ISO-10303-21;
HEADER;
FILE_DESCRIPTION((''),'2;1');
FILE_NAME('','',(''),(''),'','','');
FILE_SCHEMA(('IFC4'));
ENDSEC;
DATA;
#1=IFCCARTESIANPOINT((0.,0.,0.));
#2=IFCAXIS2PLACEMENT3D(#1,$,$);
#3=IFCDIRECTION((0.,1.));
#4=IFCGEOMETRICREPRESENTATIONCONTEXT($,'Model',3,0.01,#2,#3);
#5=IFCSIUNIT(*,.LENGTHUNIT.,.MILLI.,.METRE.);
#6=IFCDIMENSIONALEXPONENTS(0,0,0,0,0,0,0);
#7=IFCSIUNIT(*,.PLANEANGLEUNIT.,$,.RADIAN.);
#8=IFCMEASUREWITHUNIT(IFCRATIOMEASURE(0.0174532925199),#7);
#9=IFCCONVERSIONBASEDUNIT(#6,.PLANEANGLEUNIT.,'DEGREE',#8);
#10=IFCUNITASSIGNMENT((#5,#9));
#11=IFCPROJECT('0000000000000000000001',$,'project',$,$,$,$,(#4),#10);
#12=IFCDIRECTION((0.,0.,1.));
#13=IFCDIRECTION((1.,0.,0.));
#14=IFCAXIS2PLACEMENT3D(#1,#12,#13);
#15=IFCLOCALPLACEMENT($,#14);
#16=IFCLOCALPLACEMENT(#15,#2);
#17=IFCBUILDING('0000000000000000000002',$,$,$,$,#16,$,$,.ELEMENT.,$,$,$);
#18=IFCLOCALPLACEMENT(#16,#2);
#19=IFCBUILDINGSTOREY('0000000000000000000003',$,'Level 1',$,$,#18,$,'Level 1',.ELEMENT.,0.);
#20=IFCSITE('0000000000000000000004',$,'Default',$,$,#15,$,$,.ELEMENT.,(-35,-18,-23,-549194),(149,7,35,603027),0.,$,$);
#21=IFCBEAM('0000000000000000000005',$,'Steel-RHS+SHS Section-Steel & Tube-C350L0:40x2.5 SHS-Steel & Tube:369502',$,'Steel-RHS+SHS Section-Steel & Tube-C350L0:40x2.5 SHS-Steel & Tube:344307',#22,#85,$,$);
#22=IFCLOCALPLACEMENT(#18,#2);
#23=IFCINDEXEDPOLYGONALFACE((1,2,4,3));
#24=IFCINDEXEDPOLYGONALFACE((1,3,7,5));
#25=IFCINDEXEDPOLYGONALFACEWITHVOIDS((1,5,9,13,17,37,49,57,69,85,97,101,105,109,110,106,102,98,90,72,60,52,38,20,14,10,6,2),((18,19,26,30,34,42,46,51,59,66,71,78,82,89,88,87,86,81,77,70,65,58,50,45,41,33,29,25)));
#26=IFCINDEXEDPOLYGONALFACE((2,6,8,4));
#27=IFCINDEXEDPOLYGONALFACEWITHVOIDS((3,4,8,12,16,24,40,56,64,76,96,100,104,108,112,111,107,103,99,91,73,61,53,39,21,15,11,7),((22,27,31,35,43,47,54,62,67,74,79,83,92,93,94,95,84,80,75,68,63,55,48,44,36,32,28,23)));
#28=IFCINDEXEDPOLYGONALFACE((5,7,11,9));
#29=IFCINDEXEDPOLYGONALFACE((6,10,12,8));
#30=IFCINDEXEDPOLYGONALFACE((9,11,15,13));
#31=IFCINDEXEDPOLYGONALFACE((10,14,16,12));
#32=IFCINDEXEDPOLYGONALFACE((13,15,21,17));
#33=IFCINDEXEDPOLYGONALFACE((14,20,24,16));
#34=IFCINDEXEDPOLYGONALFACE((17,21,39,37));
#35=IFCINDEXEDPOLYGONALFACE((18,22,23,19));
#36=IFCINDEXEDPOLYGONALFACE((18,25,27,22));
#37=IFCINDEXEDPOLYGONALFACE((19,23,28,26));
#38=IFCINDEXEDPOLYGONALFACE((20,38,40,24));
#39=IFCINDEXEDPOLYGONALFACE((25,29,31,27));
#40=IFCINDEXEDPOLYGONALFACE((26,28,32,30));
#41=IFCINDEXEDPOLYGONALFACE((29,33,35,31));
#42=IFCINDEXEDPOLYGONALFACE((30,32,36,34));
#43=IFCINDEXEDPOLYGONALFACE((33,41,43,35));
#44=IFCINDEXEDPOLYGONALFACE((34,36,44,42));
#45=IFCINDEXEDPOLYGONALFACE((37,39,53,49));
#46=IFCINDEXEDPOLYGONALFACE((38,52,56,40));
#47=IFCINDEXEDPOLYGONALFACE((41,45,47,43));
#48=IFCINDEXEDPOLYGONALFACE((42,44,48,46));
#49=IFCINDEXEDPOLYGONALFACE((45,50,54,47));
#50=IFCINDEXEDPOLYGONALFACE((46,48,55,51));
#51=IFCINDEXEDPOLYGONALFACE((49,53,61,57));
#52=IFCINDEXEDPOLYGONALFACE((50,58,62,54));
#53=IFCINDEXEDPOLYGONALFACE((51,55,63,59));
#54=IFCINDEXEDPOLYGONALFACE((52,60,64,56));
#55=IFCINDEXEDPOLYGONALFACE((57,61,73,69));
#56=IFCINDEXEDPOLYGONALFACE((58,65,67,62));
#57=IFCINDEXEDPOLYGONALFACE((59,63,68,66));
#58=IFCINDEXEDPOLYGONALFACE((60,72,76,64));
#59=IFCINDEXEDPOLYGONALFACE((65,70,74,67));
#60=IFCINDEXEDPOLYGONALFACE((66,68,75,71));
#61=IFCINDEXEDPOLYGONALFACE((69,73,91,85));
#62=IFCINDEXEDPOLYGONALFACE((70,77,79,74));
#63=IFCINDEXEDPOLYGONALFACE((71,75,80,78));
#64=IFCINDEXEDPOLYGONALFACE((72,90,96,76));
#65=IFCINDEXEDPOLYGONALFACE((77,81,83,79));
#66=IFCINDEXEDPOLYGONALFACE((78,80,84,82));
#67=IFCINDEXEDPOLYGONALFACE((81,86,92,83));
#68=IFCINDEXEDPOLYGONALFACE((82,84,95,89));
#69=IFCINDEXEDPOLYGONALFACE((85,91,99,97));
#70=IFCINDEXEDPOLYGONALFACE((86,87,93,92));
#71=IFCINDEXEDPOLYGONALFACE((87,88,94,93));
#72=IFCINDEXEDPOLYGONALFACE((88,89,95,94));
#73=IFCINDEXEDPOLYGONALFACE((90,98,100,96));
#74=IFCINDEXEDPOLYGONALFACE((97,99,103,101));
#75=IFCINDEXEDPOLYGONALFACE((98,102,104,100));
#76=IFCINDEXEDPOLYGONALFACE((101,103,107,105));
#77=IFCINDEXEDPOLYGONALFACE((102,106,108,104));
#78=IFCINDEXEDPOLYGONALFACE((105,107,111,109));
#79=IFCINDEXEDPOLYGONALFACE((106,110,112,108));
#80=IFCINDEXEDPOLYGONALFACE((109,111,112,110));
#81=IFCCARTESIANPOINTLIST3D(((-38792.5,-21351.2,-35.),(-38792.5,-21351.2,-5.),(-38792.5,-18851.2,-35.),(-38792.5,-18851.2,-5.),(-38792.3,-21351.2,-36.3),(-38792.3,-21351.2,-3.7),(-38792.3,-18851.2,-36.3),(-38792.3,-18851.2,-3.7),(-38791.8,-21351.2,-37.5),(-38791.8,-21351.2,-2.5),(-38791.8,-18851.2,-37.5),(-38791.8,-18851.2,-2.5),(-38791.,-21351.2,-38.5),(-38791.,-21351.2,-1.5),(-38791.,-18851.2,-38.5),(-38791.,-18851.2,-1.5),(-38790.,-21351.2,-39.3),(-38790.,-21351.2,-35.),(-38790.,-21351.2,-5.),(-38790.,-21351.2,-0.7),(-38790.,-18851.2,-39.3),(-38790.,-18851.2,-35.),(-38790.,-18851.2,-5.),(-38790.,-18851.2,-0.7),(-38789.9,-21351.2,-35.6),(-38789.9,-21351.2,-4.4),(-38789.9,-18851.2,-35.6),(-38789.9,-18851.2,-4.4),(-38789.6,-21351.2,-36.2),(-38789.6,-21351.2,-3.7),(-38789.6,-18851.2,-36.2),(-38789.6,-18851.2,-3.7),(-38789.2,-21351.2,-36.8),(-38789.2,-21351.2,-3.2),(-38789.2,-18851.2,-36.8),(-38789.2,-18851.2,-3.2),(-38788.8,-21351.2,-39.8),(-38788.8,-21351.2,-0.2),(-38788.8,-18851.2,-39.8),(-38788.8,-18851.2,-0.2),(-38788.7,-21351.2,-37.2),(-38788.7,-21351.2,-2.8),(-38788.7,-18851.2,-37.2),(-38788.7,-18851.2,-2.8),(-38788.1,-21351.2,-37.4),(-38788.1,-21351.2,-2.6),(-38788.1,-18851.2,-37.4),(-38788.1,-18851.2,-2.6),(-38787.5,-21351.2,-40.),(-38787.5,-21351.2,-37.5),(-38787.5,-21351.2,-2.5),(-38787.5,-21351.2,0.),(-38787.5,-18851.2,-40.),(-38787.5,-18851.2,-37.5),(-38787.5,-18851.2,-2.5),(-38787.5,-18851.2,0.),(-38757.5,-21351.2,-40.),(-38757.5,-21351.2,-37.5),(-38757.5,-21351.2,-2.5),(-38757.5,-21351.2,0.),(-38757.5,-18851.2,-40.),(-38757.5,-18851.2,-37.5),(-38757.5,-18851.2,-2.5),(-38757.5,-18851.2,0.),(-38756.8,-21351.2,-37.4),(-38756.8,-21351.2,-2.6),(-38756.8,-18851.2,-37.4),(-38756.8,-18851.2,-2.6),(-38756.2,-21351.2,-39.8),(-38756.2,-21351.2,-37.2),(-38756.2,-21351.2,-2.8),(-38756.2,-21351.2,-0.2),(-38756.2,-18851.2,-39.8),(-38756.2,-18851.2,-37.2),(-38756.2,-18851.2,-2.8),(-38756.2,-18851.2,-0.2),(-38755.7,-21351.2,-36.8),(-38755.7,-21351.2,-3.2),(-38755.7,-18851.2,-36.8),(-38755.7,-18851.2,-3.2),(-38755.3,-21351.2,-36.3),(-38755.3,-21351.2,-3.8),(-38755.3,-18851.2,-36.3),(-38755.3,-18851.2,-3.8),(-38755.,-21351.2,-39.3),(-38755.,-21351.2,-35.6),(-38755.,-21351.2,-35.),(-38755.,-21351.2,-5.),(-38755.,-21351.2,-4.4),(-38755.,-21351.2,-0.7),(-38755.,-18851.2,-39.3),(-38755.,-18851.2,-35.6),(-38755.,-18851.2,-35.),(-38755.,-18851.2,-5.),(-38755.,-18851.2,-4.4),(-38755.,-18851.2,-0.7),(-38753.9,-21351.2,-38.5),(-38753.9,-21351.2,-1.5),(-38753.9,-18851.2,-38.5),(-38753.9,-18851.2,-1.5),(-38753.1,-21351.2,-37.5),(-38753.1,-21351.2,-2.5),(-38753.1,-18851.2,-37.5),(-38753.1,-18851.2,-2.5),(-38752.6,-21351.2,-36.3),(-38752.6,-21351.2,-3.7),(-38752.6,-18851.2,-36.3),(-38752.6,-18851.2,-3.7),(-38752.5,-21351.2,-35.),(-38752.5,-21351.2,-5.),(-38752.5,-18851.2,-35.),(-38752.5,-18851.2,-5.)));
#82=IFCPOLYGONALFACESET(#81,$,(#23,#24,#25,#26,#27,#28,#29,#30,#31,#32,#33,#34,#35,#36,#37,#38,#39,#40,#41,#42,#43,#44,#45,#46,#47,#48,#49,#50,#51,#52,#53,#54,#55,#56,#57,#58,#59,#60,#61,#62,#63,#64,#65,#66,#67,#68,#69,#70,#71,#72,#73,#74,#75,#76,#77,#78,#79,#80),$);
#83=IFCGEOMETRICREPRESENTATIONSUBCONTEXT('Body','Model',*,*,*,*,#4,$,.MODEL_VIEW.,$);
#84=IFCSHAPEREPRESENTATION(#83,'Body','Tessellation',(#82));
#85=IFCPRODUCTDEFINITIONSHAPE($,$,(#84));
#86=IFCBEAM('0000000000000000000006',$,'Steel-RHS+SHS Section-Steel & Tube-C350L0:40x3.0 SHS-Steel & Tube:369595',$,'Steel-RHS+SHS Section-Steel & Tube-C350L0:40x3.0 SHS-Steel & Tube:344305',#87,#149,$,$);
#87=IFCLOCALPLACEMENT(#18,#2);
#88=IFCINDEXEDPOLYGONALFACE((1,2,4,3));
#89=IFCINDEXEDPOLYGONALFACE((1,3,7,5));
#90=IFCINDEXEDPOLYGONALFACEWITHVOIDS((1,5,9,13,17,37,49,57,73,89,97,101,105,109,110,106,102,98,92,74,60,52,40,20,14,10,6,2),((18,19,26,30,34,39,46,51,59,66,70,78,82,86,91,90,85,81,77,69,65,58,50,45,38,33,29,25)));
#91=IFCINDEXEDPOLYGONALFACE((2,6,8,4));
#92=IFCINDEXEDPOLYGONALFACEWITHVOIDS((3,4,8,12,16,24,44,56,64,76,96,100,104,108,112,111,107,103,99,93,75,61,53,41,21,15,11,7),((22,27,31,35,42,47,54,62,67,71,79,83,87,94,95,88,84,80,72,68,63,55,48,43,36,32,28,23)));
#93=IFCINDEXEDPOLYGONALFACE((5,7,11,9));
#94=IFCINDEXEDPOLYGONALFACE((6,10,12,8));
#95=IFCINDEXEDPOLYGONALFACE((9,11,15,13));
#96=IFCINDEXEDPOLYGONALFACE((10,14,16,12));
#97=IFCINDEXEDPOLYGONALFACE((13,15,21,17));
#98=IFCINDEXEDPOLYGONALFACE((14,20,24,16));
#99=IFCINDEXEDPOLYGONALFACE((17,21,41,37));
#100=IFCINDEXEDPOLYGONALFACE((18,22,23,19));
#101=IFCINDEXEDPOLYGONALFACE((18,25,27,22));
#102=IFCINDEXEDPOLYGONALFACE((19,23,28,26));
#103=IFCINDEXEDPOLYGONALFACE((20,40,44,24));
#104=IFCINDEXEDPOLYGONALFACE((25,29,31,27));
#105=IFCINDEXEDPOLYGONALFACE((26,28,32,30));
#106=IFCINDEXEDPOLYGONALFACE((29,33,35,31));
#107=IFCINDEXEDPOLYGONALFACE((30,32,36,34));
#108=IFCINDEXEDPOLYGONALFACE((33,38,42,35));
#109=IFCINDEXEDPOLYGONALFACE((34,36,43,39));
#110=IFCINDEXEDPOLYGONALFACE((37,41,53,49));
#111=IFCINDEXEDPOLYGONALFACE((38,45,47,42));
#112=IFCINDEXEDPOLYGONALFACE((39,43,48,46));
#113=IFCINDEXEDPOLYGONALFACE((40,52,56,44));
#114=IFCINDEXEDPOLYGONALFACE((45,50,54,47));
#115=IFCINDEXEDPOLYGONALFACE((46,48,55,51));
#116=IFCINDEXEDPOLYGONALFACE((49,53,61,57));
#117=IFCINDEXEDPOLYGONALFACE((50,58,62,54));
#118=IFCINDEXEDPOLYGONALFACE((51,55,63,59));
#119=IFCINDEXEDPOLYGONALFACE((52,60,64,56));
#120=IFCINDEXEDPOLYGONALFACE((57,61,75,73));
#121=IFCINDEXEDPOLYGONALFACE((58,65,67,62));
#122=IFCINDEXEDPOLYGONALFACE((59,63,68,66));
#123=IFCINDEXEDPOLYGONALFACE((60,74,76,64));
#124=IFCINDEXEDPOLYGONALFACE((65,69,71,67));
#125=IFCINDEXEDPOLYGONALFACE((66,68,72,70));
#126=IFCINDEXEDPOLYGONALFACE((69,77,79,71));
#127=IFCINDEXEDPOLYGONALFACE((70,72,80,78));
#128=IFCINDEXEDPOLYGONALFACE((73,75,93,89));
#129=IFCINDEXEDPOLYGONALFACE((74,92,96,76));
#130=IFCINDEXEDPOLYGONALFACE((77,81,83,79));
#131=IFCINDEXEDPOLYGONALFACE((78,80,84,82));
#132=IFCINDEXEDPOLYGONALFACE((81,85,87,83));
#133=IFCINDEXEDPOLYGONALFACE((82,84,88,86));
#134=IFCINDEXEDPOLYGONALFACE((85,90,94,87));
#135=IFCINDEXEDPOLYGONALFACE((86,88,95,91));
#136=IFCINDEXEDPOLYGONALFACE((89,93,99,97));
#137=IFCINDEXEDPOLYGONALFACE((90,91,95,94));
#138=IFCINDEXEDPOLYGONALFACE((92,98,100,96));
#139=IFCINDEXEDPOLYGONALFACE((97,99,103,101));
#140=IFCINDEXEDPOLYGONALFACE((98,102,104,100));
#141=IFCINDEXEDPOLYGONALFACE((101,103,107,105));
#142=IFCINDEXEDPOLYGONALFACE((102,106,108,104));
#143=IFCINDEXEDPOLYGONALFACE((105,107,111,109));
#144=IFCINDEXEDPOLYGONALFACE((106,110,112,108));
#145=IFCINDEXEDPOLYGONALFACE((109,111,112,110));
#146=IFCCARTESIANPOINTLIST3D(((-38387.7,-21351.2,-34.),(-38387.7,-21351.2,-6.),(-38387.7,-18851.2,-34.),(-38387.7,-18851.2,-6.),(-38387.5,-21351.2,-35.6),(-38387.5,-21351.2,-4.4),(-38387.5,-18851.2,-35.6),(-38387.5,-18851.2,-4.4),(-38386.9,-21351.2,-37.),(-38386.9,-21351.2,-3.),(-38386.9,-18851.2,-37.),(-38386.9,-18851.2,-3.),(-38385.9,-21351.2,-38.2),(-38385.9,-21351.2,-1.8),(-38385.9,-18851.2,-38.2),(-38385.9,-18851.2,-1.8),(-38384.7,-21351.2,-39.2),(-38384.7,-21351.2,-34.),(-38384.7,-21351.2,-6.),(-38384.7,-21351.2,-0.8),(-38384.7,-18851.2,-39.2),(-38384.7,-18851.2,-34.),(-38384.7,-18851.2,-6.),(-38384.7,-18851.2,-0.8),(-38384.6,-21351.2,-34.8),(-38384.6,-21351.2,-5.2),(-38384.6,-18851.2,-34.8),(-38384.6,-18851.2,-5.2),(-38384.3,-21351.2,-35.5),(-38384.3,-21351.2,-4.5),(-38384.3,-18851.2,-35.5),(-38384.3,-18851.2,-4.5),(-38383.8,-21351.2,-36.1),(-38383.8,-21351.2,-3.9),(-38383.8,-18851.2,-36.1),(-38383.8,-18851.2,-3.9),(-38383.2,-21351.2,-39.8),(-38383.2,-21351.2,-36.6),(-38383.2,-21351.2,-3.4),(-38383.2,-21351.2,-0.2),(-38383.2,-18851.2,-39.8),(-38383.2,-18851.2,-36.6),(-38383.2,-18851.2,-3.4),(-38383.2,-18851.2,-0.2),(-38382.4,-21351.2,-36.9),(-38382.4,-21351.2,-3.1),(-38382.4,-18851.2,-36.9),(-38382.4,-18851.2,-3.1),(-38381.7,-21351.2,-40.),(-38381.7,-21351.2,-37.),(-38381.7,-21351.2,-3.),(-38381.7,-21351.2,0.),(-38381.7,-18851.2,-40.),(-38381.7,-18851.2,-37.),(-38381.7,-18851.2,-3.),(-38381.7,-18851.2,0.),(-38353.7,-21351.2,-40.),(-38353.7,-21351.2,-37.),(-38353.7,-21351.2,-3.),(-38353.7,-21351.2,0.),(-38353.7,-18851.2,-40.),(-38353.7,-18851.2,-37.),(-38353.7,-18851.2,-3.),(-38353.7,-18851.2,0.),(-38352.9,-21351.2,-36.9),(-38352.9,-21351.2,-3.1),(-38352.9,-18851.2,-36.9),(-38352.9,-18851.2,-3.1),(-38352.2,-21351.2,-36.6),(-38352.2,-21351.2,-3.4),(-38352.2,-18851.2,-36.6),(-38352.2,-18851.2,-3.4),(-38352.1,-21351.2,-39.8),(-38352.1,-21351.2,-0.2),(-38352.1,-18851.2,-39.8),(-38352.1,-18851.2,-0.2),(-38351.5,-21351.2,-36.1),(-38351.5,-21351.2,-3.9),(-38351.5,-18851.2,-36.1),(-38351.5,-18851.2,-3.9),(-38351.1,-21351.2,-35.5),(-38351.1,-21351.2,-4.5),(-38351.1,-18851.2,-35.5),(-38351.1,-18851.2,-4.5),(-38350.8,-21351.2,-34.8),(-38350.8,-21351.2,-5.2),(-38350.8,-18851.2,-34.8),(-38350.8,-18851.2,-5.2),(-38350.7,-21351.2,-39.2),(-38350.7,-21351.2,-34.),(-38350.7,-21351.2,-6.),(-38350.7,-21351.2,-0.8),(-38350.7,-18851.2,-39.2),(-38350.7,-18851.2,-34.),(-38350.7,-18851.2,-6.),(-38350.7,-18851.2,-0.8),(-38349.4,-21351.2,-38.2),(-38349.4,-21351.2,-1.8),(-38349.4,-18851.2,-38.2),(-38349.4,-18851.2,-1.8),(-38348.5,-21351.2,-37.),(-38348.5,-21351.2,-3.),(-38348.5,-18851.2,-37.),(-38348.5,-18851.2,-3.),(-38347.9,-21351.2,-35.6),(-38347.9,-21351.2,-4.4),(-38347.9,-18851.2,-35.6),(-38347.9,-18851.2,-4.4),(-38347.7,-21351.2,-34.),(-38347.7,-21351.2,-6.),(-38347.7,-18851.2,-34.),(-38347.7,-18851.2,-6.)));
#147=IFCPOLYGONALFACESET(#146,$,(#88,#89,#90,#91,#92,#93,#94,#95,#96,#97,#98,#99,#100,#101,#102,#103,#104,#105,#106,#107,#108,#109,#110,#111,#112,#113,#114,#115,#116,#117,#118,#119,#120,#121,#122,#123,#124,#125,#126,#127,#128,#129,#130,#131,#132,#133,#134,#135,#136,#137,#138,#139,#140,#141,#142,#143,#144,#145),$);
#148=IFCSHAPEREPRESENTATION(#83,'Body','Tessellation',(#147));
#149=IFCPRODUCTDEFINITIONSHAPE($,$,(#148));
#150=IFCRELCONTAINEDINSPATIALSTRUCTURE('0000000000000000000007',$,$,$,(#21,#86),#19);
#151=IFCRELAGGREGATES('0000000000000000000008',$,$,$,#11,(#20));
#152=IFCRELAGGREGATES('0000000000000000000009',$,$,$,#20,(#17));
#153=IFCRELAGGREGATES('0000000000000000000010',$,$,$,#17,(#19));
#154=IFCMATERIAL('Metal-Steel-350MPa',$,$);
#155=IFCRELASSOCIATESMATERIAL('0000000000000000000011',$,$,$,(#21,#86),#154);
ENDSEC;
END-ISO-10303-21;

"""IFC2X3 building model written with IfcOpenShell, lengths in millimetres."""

from ifc_helpers import new_model, entity, si_unit, converted_unit, direction, frame, frame_2d, origin, origin_with_axes, place, context, subcontext, project, spatial, polyline, circle_curve, parameter, trimmed, segment, composite_curve, outline, extrude, material, element, save


model = new_model("IFC2X3")

# Units and contexts
model_context = context("Model", 3, precision=0.01, world=origin(), true_north=direction((0.0, 1.0)))
body_context = subcontext(model_context, "Body", "Model", "MODEL_VIEW")
ifc_project = project(units=[si_unit("LENGTHUNIT", "METRE", prefix="MILLI"), converted_unit("PLANEANGLEUNIT", "DEGREE", entity("IfcRatioMeasure", 0.0174532925199), si_unit("PLANEANGLEUNIT", "RADIAN"), dimensions=[0, 0, 0, 0, 0, 0, 0])], contexts=[model_context])

# Site, building, storey
site_placement = place(None, origin_with_axes())
site = spatial("IfcSite", under=ifc_project, at=site_placement, Name="Default", CompositionType="ELEMENT", RefLatitude=(-35, -18, -23, -549194), RefLongitude=(149, 7, 35, 603027), RefElevation=0.0)
building_placement = place(site_placement, origin())
building = spatial("IfcBuilding", under=site, at=building_placement, CompositionType="ELEMENT")
storey_placement = place(building_placement, origin())
storey = spatial("IfcBuildingStorey", under=building, at=storey_placement, Name="Level 1", LongName="Level 1", CompositionType="ELEMENT", Elevation=0.0)

# Beams
ifc_material = material(Name="Metal-Steel-350MPa")
beam_1_placement = place(storey_placement, frame((-38772.5, -18851.2, 0.0), z_axis=(0.0, 0.0, 1.0), x_axis=(0.0, -1.0, 0.0)))
element("IfcBeam", 1, at=beam_1_placement, inside=storey, material=ifc_material, Name="Steel-RHS+SHS Section-Steel & Tube-C350L0:40x2.5 SHS-Steel & Tube:369502", ObjectType="Steel-RHS+SHS Section-Steel & Tube-C350L0:40x2.5 SHS-Steel & Tube:344307", context=body_context, shape_type="SweptSolid", body=[
    extrude(outline(composite_curve([segment(trimmed(circle_curve(frame_2d((-15.0, -15.0), x_axis=(1.0, 0.0)), 5.0), [parameter(180.0)], [parameter(270.0)], True, "PARAMETER"), True, "CONTINUOUS"), segment(polyline([(-15.0, -20.0), (15.0, -20.0)]), True, "CONTINUOUS"), segment(trimmed(circle_curve(frame_2d((15.0, -15.0), x_axis=(1.0, 0.0)), 5.0), [parameter(270.0)], [parameter(0.0)], True, "PARAMETER"), True, "CONTINUOUS"), segment(polyline([(20.0, -15.0), (20.0, 15.0)]), True, "CONTINUOUS"), segment(trimmed(circle_curve(frame_2d((15.0, 15.0), x_axis=(1.0, 0.0)), 5.0), [parameter(0.0)], [parameter(90.0)], True, "PARAMETER"), True, "CONTINUOUS"), segment(polyline([(15.0, 20.0), (-15.0, 20.0)]), True, "CONTINUOUS"), segment(trimmed(circle_curve(frame_2d((-15.0, 15.0), x_axis=(1.0, 0.0)), 5.0), [parameter(90.0)], [parameter(180.0)], True, "PARAMETER"), True, "CONTINUOUS"), segment(polyline([(-20.0, 15.0), (-20.0, -15.0)]), True, "CONTINUOUS")], self_intersect=False), holes=[composite_curve([segment(polyline([(15.0, -17.5), (-15.0, -17.5)]), True, "CONTINUOUS"), segment(trimmed(circle_curve(frame_2d((-15.0, -15.0), x_axis=(1.0, 0.0)), 2.5), [parameter(180.0)], [parameter(270.0)], True, "PARAMETER"), False, "CONTINUOUS"), segment(polyline([(-17.5, -15.0), (-17.5, 15.0)]), True, "CONTINUOUS"), segment(trimmed(circle_curve(frame_2d((-15.0, 15.0), x_axis=(1.0, 0.0)), 2.5), [parameter(90.0)], [parameter(180.0)], True, "PARAMETER"), False, "CONTINUOUS"), segment(polyline([(-15.0, 17.5), (15.0, 17.5)]), True, "CONTINUOUS"), segment(trimmed(circle_curve(frame_2d((15.0, 15.0), x_axis=(1.0, 0.0)), 2.5), [parameter(360.0)], [parameter(90.0)], True, "PARAMETER"), False, "CONTINUOUS"), segment(polyline([(17.5, 15.0), (17.5, -15.0)]), True, "CONTINUOUS"), segment(trimmed(circle_curve(frame_2d((15.0, -15.0), x_axis=(1.0, 0.0)), 2.5), [parameter(270.0)], [parameter(360.0)], True, "PARAMETER"), False, "CONTINUOUS")], self_intersect=False)]), frame((0.0, 0.0, -20.0), z_axis=(1.0, 0.0, 0.0), x_axis=(0.0, -1.0, 0.0)), (0.0, 0.0, 1.0), 2500.0),
])
beam_2_placement = place(storey_placement, frame((-38367.7, -18851.2, 0.0), z_axis=(0.0, 0.0, 1.0), x_axis=(0.0, -1.0, 0.0)))
element("IfcBeam", 2, at=beam_2_placement, inside=storey, material=ifc_material, Name="Steel-RHS+SHS Section-Steel & Tube-C350L0:40x3.0 SHS-Steel & Tube:369595", ObjectType="Steel-RHS+SHS Section-Steel & Tube-C350L0:40x3.0 SHS-Steel & Tube:344305", context=body_context, shape_type="SweptSolid", body=[
    extrude(outline(composite_curve([segment(trimmed(circle_curve(frame_2d((-14.0, -14.0), x_axis=(1.0, 0.0)), 6.0), [parameter(180.0)], [parameter(270.0)], True, "PARAMETER"), True, "CONTINUOUS"), segment(polyline([(-14.0, -20.0), (14.0, -20.0)]), True, "CONTINUOUS"), segment(trimmed(circle_curve(frame_2d((14.0, -14.0), x_axis=(1.0, 0.0)), 6.0), [parameter(270.0)], [parameter(0.0)], True, "PARAMETER"), True, "CONTINUOUS"), segment(polyline([(20.0, -14.0), (20.0, 14.0)]), True, "CONTINUOUS"), segment(trimmed(circle_curve(frame_2d((14.0, 14.0), x_axis=(1.0, 0.0)), 6.0), [parameter(0.0)], [parameter(90.0)], True, "PARAMETER"), True, "CONTINUOUS"), segment(polyline([(14.0, 20.0), (-14.0, 20.0)]), True, "CONTINUOUS"), segment(trimmed(circle_curve(frame_2d((-14.0, 14.0), x_axis=(1.0, 0.0)), 6.0), [parameter(90.0)], [parameter(180.0)], True, "PARAMETER"), True, "CONTINUOUS"), segment(polyline([(-20.0, 14.0), (-20.0, -14.0)]), True, "CONTINUOUS")], self_intersect=False), holes=[composite_curve([segment(polyline([(14.0, -17.0), (-14.0, -17.0)]), True, "CONTINUOUS"), segment(trimmed(circle_curve(frame_2d((-14.0, -14.0), x_axis=(1.0, 0.0)), 3.0), [parameter(180.0)], [parameter(270.0)], True, "PARAMETER"), False, "CONTINUOUS"), segment(polyline([(-17.0, -14.0), (-17.0, 14.0)]), True, "CONTINUOUS"), segment(trimmed(circle_curve(frame_2d((-14.0, 14.0), x_axis=(1.0, 0.0)), 3.0), [parameter(90.0)], [parameter(180.0)], True, "PARAMETER"), False, "CONTINUOUS"), segment(polyline([(-14.0, 17.0), (14.0, 17.0)]), True, "CONTINUOUS"), segment(trimmed(circle_curve(frame_2d((14.0, 14.0), x_axis=(1.0, 0.0)), 3.0), [parameter(360.0)], [parameter(90.0)], True, "PARAMETER"), False, "CONTINUOUS"), segment(polyline([(17.0, 14.0), (17.0, -14.0)]), True, "CONTINUOUS"), segment(trimmed(circle_curve(frame_2d((14.0, -14.0), x_axis=(1.0, 0.0)), 3.0), [parameter(270.0)], [parameter(360.0)], True, "PARAMETER"), False, "CONTINUOUS")], self_intersect=False)]), frame((0.0, 0.0, -20.0), z_axis=(1.0, 0.0, 0.0), x_axis=(0.0, -1.0, 0.0)), (0.0, 0.0, 1.0), 2500.0),
])

save(model, "model.ifc")
